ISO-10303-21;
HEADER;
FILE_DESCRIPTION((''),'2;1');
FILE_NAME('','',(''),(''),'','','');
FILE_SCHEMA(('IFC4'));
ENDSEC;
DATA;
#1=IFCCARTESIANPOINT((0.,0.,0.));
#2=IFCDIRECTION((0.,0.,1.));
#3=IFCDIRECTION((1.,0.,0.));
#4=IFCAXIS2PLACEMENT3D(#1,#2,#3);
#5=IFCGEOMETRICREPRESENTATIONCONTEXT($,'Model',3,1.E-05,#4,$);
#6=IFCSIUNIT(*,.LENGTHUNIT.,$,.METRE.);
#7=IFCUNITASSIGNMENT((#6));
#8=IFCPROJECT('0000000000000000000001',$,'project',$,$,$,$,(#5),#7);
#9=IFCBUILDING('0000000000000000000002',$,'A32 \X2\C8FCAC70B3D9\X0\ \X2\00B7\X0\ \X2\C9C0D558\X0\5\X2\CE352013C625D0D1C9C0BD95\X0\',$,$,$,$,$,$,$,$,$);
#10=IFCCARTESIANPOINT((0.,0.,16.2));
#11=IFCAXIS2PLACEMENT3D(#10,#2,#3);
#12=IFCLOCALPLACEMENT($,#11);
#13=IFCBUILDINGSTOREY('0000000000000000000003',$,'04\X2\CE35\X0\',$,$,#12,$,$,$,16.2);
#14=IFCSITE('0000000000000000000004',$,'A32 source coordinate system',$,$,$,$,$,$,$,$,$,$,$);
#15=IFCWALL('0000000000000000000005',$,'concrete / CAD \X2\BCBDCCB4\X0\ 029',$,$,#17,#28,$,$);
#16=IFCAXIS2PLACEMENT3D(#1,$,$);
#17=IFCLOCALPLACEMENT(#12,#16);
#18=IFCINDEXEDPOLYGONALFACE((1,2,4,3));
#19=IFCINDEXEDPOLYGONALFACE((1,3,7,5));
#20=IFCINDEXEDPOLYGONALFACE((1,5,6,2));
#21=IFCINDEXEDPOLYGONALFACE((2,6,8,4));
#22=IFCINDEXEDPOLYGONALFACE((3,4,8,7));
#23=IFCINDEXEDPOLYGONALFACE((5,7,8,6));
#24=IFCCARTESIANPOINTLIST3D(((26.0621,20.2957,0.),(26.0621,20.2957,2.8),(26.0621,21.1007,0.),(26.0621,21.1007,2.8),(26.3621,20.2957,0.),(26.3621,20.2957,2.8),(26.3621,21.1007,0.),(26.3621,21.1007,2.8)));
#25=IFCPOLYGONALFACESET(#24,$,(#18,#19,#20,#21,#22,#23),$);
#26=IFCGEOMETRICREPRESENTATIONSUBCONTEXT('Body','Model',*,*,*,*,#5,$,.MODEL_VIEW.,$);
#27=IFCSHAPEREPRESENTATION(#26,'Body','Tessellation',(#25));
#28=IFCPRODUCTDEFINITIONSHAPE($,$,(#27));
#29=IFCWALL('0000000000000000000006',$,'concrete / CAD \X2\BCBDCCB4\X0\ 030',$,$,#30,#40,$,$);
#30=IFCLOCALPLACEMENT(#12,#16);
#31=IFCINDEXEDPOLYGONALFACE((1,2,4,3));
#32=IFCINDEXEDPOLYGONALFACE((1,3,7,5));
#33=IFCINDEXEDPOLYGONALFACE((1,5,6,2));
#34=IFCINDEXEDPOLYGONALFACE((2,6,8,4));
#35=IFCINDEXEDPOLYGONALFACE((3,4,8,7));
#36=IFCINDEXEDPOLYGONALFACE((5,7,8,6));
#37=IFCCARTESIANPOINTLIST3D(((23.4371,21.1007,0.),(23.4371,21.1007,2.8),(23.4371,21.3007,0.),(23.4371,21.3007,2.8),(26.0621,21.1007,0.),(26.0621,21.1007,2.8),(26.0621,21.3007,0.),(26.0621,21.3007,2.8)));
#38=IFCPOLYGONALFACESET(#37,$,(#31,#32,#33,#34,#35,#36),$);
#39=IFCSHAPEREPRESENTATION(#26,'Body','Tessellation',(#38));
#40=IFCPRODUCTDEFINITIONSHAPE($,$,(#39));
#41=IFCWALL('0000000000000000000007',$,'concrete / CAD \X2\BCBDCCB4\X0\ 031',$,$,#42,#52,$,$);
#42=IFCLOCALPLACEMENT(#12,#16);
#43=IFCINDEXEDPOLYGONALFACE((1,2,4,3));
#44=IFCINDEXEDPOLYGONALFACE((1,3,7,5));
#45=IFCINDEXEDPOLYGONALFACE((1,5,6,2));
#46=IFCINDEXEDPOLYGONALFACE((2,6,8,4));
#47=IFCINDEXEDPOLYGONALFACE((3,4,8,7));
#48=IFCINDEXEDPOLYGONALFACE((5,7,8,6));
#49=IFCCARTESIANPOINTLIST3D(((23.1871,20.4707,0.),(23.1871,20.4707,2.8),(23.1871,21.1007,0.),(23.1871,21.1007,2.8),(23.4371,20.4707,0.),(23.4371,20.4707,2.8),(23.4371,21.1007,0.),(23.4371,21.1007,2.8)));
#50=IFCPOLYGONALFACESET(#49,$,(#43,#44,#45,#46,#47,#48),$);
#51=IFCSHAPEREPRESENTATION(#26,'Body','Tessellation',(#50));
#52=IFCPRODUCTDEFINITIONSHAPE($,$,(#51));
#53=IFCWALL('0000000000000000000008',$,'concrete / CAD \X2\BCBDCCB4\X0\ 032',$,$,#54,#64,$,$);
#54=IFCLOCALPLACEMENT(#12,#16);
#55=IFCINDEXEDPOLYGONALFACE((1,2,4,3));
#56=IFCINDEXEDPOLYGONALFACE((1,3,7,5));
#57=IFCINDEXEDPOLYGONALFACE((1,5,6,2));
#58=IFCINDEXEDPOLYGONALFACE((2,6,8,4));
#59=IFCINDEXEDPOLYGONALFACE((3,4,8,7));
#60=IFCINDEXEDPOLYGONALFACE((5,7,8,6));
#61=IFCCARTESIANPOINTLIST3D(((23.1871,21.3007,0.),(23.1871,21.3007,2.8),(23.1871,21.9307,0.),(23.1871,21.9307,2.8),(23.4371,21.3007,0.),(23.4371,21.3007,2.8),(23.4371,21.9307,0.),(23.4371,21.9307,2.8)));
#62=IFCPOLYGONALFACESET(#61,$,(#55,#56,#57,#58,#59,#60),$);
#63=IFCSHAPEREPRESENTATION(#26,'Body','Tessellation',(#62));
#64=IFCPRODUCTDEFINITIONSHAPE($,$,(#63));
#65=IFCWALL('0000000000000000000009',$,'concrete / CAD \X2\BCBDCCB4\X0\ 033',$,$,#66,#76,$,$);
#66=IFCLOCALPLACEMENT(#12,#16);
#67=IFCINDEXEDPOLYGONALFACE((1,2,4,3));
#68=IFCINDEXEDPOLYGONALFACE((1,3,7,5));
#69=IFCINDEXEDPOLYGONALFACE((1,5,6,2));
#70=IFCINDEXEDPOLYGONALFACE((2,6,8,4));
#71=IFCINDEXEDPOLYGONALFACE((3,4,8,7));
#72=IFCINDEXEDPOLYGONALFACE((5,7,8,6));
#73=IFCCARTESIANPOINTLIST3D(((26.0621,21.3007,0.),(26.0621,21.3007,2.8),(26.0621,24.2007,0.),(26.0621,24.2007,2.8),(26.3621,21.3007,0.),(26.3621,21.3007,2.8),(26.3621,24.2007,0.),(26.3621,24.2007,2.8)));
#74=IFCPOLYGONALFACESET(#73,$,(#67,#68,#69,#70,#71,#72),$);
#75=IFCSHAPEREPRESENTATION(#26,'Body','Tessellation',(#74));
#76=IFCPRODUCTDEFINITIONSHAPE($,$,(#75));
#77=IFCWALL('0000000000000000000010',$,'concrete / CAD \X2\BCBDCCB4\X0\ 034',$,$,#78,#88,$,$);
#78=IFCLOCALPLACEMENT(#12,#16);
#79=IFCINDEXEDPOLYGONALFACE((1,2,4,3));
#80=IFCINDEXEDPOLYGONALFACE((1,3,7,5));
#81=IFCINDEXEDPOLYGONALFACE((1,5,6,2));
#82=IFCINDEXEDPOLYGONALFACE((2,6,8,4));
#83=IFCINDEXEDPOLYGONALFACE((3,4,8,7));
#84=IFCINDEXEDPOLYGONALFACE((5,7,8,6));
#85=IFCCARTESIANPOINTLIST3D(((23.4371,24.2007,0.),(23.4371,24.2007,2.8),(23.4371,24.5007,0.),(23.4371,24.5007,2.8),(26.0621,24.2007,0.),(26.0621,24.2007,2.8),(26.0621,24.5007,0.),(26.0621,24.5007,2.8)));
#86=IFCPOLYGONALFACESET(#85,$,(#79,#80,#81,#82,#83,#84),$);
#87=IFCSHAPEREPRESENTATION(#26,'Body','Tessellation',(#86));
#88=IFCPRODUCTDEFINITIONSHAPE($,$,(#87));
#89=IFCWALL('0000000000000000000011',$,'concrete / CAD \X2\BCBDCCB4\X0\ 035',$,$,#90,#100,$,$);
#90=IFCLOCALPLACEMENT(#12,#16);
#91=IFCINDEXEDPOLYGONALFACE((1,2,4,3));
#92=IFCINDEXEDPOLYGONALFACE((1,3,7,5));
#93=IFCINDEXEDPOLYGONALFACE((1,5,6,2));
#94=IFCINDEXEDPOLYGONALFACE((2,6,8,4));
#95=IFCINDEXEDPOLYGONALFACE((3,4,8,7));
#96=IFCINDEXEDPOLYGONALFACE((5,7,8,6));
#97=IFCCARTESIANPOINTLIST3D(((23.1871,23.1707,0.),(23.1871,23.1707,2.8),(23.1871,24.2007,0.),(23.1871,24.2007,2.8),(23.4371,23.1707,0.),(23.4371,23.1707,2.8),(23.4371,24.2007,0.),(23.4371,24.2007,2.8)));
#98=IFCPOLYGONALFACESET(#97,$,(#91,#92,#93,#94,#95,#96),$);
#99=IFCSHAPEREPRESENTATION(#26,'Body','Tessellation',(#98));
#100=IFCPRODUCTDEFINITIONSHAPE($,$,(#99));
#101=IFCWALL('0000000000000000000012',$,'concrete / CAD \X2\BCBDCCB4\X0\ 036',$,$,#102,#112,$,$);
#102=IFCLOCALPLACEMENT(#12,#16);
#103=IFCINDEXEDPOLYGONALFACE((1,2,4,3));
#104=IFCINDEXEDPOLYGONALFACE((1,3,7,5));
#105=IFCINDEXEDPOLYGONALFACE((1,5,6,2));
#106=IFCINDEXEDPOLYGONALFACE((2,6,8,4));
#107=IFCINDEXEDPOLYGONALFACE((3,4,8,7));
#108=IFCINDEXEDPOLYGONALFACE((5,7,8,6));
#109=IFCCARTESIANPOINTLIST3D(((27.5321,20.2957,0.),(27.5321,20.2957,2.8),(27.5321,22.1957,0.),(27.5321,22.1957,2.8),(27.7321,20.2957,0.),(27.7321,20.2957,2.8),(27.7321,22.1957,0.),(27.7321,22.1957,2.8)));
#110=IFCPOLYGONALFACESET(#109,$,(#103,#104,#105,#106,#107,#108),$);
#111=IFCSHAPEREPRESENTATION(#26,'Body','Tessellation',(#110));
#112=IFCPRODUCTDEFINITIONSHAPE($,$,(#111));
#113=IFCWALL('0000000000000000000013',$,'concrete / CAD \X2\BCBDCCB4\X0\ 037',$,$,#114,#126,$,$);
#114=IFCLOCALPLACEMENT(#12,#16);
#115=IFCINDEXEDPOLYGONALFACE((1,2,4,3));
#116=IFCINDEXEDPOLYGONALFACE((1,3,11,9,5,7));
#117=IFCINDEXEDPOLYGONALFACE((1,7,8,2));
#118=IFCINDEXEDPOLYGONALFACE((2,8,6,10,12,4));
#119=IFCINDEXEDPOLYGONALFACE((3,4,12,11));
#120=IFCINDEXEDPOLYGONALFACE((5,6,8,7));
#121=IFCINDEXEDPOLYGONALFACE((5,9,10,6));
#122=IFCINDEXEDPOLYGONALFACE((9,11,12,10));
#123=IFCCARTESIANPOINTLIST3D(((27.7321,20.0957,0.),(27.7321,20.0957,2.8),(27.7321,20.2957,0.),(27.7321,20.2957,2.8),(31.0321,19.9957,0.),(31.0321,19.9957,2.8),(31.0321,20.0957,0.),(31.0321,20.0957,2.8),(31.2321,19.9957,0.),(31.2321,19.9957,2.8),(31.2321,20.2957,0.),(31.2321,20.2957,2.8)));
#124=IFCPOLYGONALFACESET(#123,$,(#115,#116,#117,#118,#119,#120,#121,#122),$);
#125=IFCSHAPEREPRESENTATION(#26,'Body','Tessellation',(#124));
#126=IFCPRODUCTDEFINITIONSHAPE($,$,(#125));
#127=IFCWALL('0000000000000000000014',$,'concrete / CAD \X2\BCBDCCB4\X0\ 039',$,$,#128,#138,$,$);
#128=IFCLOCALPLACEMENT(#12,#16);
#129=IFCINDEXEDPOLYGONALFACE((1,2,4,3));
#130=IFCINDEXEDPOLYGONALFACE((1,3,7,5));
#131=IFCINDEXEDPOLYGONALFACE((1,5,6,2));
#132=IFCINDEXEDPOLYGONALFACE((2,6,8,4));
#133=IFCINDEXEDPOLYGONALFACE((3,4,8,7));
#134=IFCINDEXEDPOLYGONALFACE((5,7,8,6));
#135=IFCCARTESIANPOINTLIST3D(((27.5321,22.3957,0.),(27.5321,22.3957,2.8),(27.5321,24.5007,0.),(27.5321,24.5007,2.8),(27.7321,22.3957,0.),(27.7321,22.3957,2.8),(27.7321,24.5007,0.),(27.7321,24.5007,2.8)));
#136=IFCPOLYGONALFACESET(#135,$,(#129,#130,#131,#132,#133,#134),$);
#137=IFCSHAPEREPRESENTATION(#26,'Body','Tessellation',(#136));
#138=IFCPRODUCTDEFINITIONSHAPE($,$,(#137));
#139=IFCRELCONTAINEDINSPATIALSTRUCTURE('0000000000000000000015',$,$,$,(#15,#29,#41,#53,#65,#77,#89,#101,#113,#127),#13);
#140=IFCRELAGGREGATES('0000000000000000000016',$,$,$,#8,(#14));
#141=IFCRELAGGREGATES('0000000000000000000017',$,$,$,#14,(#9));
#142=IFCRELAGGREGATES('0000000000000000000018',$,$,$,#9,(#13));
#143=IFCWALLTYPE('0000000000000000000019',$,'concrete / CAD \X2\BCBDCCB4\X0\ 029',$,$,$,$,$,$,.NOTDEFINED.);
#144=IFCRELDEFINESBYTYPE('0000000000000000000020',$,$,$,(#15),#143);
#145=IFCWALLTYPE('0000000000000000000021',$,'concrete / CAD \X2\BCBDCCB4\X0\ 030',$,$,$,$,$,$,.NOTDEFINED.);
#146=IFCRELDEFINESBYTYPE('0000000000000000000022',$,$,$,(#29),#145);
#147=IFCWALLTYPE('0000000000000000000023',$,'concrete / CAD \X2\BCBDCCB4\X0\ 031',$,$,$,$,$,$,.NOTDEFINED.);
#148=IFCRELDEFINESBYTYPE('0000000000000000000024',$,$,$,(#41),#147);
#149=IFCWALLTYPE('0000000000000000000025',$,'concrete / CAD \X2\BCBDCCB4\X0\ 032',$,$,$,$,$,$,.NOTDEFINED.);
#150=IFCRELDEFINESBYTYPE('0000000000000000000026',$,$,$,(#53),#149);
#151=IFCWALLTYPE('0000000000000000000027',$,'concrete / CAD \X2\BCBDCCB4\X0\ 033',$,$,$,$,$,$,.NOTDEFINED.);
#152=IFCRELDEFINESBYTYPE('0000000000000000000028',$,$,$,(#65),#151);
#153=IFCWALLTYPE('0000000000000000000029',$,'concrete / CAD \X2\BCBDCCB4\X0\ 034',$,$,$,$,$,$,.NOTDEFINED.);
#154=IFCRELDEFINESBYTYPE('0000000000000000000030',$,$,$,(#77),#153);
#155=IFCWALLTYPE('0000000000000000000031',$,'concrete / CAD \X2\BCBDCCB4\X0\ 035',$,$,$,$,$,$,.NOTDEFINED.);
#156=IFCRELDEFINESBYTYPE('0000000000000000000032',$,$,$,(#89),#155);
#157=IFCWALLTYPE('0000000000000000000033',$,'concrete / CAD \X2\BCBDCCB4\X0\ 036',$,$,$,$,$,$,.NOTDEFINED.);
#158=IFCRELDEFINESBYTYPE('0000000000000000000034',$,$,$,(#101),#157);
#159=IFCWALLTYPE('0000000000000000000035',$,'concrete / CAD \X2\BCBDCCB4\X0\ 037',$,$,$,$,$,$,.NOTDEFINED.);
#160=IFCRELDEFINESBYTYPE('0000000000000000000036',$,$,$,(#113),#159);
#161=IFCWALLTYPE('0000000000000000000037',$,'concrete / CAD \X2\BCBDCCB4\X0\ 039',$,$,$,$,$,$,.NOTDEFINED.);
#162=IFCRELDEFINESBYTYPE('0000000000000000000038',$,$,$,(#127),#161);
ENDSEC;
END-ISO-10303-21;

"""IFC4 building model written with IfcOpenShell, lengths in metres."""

from ifc_helpers import new_model, si_unit, frame, origin, origin_with_axes, place, context, subcontext, project, spatial, polyline, outline, extrude, source, transform, mapped, type_object, type_shapes, element, save


model = new_model("IFC4")

# Units and contexts
model_context = context("Model", 3, precision=1e-05, world=origin_with_axes())
body_context = subcontext(model_context, "Body", "Model", "MODEL_VIEW")
ifc_project = project(units=[si_unit("LENGTHUNIT", "METRE")], contexts=[model_context])

# Site, building, storey
site = spatial("IfcSite", under=ifc_project, Name="A32 source coordinate system")
building = spatial("IfcBuilding", under=site, Name="A32 주거동 · 지하5층–옥탑지붕")
storey_placement = place(None, frame((0.0, 0.0, 16.2), z_axis=(0.0, 0.0, 1.0), x_axis=(1.0, 0.0, 0.0)))
storey = spatial("IfcBuildingStorey", under=building, at=storey_placement, Name="04층", Elevation=16.2)

# Walls
wall_type_1 = type_object("IfcWallType", Name="concrete / CAD 벽체 029", PredefinedType="NOTDEFINED")
shared_shape_1 = source(origin(), body_context, "Body", "SweptSolid", [
    extrude(outline(polyline([(26.3621, 20.2957), (26.0621, 20.2957), (26.0621, 21.1007), (26.3621, 21.1007), (26.3621, 20.2957)])), origin(), (0.0, 0.0, 1.0), 2.8),
])
type_shapes(wall_type_1, [shared_shape_1])
wall_1_placement = place(storey_placement, origin_with_axes())
element("IfcWall", 1, at=wall_1_placement, inside=storey, type_object=wall_type_1, Name="concrete / CAD 벽체 029", context=body_context, shape_type="MappedRepresentation", body=[
    mapped(shared_shape_1, transform((0.0, 0.0, 0.0), scale=1.0)),
])
wall_type_2 = type_object("IfcWallType", Name="concrete / CAD 벽체 030", PredefinedType="NOTDEFINED")
shared_shape_2 = source(origin(), body_context, "Body", "SweptSolid", [
    extrude(outline(polyline([(26.0621, 21.3007), (26.0621, 21.1007), (23.4371, 21.1007), (23.4371, 21.3007), (26.0621, 21.3007)])), origin(), (0.0, 0.0, 1.0), 2.8),
])
type_shapes(wall_type_2, [shared_shape_2])
wall_2_placement = place(storey_placement, origin_with_axes())
element("IfcWall", 2, at=wall_2_placement, inside=storey, type_object=wall_type_2, Name="concrete / CAD 벽체 030", context=body_context, shape_type="MappedRepresentation", body=[
    mapped(shared_shape_2, transform((0.0, 0.0, 0.0), scale=1.0)),
])
wall_type_3 = type_object("IfcWallType", Name="concrete / CAD 벽체 031", PredefinedType="NOTDEFINED")
shared_shape_3 = source(origin(), body_context, "Body", "SweptSolid", [
    extrude(outline(polyline([(23.1871, 21.1007), (23.4371, 21.1007), (23.4371, 20.4707), (23.1871, 20.4707), (23.1871, 21.1007)])), origin(), (0.0, 0.0, 1.0), 2.8),
])
type_shapes(wall_type_3, [shared_shape_3])
wall_3_placement = place(storey_placement, origin_with_axes())
element("IfcWall", 3, at=wall_3_placement, inside=storey, type_object=wall_type_3, Name="concrete / CAD 벽체 031", context=body_context, shape_type="MappedRepresentation", body=[
    mapped(shared_shape_3, transform((0.0, 0.0, 0.0), scale=1.0)),
])
wall_type_4 = type_object("IfcWallType", Name="concrete / CAD 벽체 032", PredefinedType="NOTDEFINED")
shared_shape_4 = source(origin(), body_context, "Body", "SweptSolid", [
    extrude(outline(polyline([(23.4371, 21.3007), (23.1871, 21.3007), (23.1871, 21.9307), (23.4371, 21.9307), (23.4371, 21.3007)])), origin(), (0.0, 0.0, 1.0), 2.8),
])
type_shapes(wall_type_4, [shared_shape_4])
wall_4_placement = place(storey_placement, origin_with_axes())
element("IfcWall", 4, at=wall_4_placement, inside=storey, type_object=wall_type_4, Name="concrete / CAD 벽체 032", context=body_context, shape_type="MappedRepresentation", body=[
    mapped(shared_shape_4, transform((0.0, 0.0, 0.0), scale=1.0)),
])
wall_type_5 = type_object("IfcWallType", Name="concrete / CAD 벽체 033", PredefinedType="NOTDEFINED")
shared_shape_5 = source(origin(), body_context, "Body", "SweptSolid", [
    extrude(outline(polyline([(26.3621, 21.3007), (26.0621, 21.3007), (26.0621, 24.2007), (26.3621, 24.2007), (26.3621, 21.3007)])), origin(), (0.0, 0.0, 1.0), 2.8),
])
type_shapes(wall_type_5, [shared_shape_5])
wall_5_placement = place(storey_placement, origin_with_axes())
element("IfcWall", 5, at=wall_5_placement, inside=storey, type_object=wall_type_5, Name="concrete / CAD 벽체 033", context=body_context, shape_type="MappedRepresentation", body=[
    mapped(shared_shape_5, transform((0.0, 0.0, 0.0), scale=1.0)),
])
wall_type_6 = type_object("IfcWallType", Name="concrete / CAD 벽체 034", PredefinedType="NOTDEFINED")
shared_shape_6 = source(origin(), body_context, "Body", "SweptSolid", [
    extrude(outline(polyline([(26.0621, 24.5007), (26.0621, 24.2007), (23.4371, 24.2007), (23.4371, 24.5007), (26.0621, 24.5007)])), origin(), (0.0, 0.0, 1.0), 2.8),
])
type_shapes(wall_type_6, [shared_shape_6])
wall_6_placement = place(storey_placement, origin_with_axes())
element("IfcWall", 6, at=wall_6_placement, inside=storey, type_object=wall_type_6, Name="concrete / CAD 벽체 034", context=body_context, shape_type="MappedRepresentation", body=[
    mapped(shared_shape_6, transform((0.0, 0.0, 0.0), scale=1.0)),
])
wall_type_7 = type_object("IfcWallType", Name="concrete / CAD 벽체 035", PredefinedType="NOTDEFINED")
shared_shape_7 = source(origin(), body_context, "Body", "SweptSolid", [
    extrude(outline(polyline([(23.1871, 24.2007), (23.4371, 24.2007), (23.4371, 23.1707), (23.1871, 23.1707), (23.1871, 24.2007)])), origin(), (0.0, 0.0, 1.0), 2.8),
])
type_shapes(wall_type_7, [shared_shape_7])
wall_7_placement = place(storey_placement, origin_with_axes())
element("IfcWall", 7, at=wall_7_placement, inside=storey, type_object=wall_type_7, Name="concrete / CAD 벽체 035", context=body_context, shape_type="MappedRepresentation", body=[
    mapped(shared_shape_7, transform((0.0, 0.0, 0.0), scale=1.0)),
])
wall_type_8 = type_object("IfcWallType", Name="concrete / CAD 벽체 036", PredefinedType="NOTDEFINED")
shared_shape_8 = source(origin(), body_context, "Body", "SweptSolid", [
    extrude(outline(polyline([(27.7321, 20.2957), (27.5321, 20.2957), (27.5321, 22.1957), (27.7321, 22.1957), (27.7321, 20.2957)])), origin(), (0.0, 0.0, 1.0), 2.8),
])
type_shapes(wall_type_8, [shared_shape_8])
wall_8_placement = place(storey_placement, origin_with_axes())
element("IfcWall", 8, at=wall_8_placement, inside=storey, type_object=wall_type_8, Name="concrete / CAD 벽체 036", context=body_context, shape_type="MappedRepresentation", body=[
    mapped(shared_shape_8, transform((0.0, 0.0, 0.0), scale=1.0)),
])
wall_type_9 = type_object("IfcWallType", Name="concrete / CAD 벽체 037", PredefinedType="NOTDEFINED")
shared_shape_9 = source(origin(), body_context, "Body", "SweptSolid", [
    extrude(outline(polyline([(31.0321, 19.9957), (31.0321, 20.0957), (27.7321, 20.0957), (27.7321, 20.2957), (31.2321, 20.2957), (31.2321, 19.9957), (31.0321, 19.9957)])), origin(), (0.0, 0.0, 1.0), 2.8),
])
type_shapes(wall_type_9, [shared_shape_9])
wall_9_placement = place(storey_placement, origin_with_axes())
element("IfcWall", 9, at=wall_9_placement, inside=storey, type_object=wall_type_9, Name="concrete / CAD 벽체 037", context=body_context, shape_type="MappedRepresentation", body=[
    mapped(shared_shape_9, transform((0.0, 0.0, 0.0), scale=1.0)),
])
wall_type_10 = type_object("IfcWallType", Name="concrete / CAD 벽체 039", PredefinedType="NOTDEFINED")
shared_shape_10 = source(origin(), body_context, "Body", "SweptSolid", [
    extrude(outline(polyline([(27.7321, 22.3957), (27.5321, 22.3957), (27.5321, 24.5007), (27.7321, 24.5007), (27.7321, 22.3957)])), origin(), (0.0, 0.0, 1.0), 2.8),
])
type_shapes(wall_type_10, [shared_shape_10])
wall_10_placement = place(storey_placement, origin_with_axes())
element("IfcWall", 10, at=wall_10_placement, inside=storey, type_object=wall_type_10, Name="concrete / CAD 벽체 039", context=body_context, shape_type="MappedRepresentation", body=[
    mapped(shared_shape_10, transform((0.0, 0.0, 0.0), scale=1.0)),
])

save(model, "model.ifc")
